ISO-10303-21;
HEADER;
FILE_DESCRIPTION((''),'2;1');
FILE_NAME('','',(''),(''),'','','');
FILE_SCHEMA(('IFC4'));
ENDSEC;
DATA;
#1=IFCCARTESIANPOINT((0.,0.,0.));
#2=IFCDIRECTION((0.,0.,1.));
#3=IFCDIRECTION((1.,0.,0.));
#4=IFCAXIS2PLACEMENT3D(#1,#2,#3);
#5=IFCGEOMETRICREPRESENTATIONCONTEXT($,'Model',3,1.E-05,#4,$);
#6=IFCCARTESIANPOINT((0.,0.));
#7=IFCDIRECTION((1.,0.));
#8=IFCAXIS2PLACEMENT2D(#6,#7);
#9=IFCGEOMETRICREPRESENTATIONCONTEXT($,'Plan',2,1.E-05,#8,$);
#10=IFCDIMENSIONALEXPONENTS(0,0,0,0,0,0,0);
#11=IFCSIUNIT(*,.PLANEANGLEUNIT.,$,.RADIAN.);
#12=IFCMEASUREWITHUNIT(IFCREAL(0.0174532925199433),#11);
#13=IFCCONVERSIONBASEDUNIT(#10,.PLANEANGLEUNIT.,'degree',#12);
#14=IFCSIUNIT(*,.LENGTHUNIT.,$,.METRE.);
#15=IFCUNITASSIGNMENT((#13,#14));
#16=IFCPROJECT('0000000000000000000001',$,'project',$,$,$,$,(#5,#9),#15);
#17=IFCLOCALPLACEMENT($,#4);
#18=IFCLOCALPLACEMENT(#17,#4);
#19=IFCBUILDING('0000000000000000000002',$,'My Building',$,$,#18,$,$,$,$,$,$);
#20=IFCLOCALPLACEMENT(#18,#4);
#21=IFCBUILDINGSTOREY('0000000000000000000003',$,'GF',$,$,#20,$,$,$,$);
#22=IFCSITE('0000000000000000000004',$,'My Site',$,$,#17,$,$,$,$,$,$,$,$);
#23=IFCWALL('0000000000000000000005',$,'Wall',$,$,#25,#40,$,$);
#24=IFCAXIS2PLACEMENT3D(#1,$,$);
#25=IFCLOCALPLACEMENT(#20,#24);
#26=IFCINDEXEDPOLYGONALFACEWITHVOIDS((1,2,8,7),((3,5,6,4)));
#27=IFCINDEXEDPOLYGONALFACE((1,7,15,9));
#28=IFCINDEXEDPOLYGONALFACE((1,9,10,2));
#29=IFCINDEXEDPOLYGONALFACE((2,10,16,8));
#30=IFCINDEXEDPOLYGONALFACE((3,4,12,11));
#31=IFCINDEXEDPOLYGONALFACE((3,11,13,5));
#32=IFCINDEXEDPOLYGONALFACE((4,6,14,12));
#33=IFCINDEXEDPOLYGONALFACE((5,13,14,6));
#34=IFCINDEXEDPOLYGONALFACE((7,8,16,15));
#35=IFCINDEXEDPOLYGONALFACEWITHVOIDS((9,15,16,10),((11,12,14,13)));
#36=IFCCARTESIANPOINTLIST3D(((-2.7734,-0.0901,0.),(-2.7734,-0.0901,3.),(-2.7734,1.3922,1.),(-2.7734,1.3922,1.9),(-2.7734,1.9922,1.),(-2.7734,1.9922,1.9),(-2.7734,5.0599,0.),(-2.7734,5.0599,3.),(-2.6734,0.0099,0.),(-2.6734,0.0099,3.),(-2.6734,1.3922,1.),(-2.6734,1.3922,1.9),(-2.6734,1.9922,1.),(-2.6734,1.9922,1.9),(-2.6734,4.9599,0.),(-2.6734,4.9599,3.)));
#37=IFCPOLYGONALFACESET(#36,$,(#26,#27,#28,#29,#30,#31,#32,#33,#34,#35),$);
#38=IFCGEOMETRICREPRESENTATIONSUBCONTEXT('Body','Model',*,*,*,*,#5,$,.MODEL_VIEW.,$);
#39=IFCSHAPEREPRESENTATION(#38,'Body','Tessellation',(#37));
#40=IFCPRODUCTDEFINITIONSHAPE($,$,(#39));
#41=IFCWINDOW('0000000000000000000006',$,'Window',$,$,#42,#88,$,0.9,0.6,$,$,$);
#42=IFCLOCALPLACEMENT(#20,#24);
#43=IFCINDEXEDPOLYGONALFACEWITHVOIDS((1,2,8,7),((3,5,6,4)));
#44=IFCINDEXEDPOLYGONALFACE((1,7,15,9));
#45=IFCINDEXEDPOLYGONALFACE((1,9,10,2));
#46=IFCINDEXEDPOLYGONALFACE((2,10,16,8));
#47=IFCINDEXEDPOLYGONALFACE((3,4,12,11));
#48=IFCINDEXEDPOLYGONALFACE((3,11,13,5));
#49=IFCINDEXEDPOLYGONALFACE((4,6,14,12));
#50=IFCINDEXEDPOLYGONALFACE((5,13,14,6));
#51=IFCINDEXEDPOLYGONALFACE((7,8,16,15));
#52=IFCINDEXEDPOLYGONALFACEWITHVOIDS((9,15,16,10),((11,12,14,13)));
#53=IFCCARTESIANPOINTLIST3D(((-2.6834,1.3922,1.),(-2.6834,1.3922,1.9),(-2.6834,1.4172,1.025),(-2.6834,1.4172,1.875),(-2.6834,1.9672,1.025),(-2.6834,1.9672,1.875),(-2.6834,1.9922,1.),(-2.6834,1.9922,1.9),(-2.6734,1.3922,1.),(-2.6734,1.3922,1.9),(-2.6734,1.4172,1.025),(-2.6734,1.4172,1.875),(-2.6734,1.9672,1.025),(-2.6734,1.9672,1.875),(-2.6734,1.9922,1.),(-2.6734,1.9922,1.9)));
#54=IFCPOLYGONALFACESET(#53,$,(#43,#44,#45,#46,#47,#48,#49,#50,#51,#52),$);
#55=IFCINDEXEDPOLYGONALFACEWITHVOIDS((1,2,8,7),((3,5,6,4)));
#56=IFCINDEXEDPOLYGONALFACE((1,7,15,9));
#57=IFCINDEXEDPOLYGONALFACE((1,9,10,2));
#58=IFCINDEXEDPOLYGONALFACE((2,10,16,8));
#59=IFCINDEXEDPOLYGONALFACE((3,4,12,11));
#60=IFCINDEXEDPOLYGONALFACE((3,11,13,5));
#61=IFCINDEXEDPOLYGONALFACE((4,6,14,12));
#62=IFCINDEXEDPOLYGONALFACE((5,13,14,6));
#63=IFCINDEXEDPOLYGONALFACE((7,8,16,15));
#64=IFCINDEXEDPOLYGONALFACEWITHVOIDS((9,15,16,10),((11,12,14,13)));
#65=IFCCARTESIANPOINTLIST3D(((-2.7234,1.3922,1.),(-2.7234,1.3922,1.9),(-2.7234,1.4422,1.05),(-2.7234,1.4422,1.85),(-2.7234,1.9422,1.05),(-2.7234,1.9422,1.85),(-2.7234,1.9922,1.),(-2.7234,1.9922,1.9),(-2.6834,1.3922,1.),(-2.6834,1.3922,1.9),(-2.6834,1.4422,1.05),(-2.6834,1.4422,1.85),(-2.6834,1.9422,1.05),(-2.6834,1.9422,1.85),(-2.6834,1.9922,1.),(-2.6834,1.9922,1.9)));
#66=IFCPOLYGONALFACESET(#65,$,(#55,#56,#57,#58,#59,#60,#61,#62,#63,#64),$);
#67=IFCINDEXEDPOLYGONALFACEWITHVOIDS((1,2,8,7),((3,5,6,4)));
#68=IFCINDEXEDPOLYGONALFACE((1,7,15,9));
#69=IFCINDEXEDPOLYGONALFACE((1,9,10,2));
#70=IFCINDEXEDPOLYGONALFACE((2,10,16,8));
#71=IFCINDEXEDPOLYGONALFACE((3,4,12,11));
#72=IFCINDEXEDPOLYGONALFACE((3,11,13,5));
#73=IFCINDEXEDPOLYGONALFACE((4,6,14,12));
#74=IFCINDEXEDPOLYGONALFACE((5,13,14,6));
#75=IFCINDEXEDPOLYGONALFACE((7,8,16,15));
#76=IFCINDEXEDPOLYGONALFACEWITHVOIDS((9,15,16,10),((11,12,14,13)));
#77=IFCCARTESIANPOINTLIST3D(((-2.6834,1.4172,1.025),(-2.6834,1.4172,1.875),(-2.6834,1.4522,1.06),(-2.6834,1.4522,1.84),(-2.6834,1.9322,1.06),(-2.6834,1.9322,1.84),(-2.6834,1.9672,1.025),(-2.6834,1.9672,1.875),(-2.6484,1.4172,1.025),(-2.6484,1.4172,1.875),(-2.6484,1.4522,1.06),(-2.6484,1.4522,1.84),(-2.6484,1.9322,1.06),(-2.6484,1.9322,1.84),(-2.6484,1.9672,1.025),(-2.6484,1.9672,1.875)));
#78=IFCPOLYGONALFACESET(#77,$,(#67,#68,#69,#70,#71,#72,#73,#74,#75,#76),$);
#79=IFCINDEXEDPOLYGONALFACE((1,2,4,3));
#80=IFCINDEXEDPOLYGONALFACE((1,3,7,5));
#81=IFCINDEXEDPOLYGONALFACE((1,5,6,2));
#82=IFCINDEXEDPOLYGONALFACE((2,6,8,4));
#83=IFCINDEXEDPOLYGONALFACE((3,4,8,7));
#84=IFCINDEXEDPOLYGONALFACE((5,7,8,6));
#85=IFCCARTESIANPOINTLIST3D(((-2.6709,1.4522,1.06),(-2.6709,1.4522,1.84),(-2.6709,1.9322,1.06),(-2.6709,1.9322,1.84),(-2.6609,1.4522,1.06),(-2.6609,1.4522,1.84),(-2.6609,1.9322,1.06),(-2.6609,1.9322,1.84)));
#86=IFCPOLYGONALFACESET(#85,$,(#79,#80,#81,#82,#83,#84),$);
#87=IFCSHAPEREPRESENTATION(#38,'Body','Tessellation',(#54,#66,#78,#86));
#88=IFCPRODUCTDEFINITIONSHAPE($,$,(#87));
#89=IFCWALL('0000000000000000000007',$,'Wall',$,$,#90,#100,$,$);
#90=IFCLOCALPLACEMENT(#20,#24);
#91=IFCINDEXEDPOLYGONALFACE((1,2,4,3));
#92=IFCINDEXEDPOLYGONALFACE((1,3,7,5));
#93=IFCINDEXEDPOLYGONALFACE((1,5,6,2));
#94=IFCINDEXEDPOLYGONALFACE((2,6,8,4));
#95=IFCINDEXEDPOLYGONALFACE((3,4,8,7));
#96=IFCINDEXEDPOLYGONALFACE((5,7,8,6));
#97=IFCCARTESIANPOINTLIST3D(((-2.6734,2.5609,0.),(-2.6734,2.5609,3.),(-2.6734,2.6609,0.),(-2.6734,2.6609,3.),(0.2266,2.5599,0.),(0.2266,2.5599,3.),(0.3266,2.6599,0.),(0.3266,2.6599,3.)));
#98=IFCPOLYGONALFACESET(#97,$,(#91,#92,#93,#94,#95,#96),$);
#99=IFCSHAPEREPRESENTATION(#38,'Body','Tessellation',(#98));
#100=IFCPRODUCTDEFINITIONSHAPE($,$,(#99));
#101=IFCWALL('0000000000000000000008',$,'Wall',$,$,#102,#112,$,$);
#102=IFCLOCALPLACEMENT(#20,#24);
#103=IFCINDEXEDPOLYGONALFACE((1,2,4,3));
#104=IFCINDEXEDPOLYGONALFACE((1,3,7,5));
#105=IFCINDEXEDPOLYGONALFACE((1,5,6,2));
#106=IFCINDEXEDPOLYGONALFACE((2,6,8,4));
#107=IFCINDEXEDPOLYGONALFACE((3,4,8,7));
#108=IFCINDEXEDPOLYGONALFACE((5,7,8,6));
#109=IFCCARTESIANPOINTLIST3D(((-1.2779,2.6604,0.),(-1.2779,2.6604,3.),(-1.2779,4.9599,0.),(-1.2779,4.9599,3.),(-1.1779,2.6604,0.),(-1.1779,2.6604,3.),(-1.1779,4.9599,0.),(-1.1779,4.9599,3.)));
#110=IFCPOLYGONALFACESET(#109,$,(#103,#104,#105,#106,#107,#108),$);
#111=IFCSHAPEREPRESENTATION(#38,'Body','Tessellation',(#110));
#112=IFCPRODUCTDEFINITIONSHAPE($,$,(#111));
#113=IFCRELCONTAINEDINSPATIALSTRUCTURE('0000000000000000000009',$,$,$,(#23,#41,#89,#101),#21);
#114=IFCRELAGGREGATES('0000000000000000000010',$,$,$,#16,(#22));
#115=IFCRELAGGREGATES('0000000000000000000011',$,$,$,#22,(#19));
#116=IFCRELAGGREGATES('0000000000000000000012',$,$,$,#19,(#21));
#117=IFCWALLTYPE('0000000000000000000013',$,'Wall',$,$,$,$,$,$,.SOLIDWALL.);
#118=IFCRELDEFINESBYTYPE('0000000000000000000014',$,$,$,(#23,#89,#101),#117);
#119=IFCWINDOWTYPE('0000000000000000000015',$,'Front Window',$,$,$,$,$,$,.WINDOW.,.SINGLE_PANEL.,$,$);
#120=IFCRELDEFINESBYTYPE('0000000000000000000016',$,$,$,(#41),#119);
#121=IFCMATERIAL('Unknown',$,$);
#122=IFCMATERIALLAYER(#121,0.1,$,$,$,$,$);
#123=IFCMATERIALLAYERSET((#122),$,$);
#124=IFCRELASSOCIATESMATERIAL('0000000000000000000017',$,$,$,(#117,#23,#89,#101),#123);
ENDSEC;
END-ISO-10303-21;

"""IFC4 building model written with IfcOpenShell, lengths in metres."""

from ifc_helpers import new_model, entity, si_unit, converted_unit, frame, origin_with_axes, origin_2d_with_axis, place, context, subcontext, project, spatial, line, indexed_curve, outline, extrude, shape, source, transform, mapped, material, layer, layer_set, layer_usage, type_object, type_shapes, element, fill, save


model = new_model("IFC4")

# Units and contexts
model_context = context("Model", 3, precision=1e-05, world=origin_with_axes())
plan_context = context("Plan", 2, precision=1e-05, world=origin_2d_with_axis())
body_context_1 = subcontext(model_context, "Body", "Model", "MODEL_VIEW")
body_context_2 = subcontext(plan_context, "Body", "Plan", "PLAN_VIEW")
ifc_project = project(units=[converted_unit("PLANEANGLEUNIT", "degree", entity("IfcReal", 0.0174532925199433), si_unit("PLANEANGLEUNIT", "RADIAN"), dimensions=[0, 0, 0, 0, 0, 0, 0]), si_unit("LENGTHUNIT", "METRE")], contexts=[model_context, plan_context])

# Site, building, storey
site_placement = place(None, origin_with_axes())
site = spatial("IfcSite", under=ifc_project, at=site_placement, Name="My Site")
building_placement = place(site_placement, origin_with_axes())
building = spatial("IfcBuilding", under=site, at=building_placement, Name="My Building")
storey_placement = place(building_placement, origin_with_axes())
storey = spatial("IfcBuildingStorey", under=building, at=storey_placement, Name="GF")

# Shared definitions
ifc_material = material(Name="Unknown")

# Shared definitions
ifc_layer = layer(ifc_material, 0.1)
ifc_layer_set = layer_set([ifc_layer])
wall_type = type_object("IfcWallType", Name="Wall", PredefinedType="SOLIDWALL", material=ifc_layer_set)

# Wall, opening, window
ifc_layer_usage_1 = layer_usage(ifc_layer_set, "AXIS2", "POSITIVE", 0.0)
wall_1_placement = place(storey_placement, frame((-2.7734, 5.0599, 0.0), z_axis=(0.0, 0.0, 1.0), x_axis=(0.0, -1.0, 0.0)))
wall_1 = element("IfcWall", 1, at=wall_1_placement, inside=storey, type_object=wall_type, material=ifc_layer_usage_1, Name="Wall", context=body_context_1, shape_type="SweptSolid", body=[
    extrude(outline(indexed_curve([(0.0, 0.0), (0.1, 0.1), (5.05, 0.1), (5.15, 0.0)], segments=[line(1, 2, 3, 4, 1)])), origin_with_axes(), (0.0, 0.0, 1.0), 3.0),
])
shared_shape_1 = source(origin_with_axes(), body_context_1, "Body", "SweptSolid", [
    extrude(outline(indexed_curve([(0.0, 0.0), (0.6, 0.0), (0.6, 0.9), (0.0, 0.9)], segments=[line(1, 2, 3, 4, 1)])), frame((0.0, -0.6, 0.0), z_axis=(0.0, -1.0, 0.0), x_axis=(1.0, 0.0, 0.0)), (0.0, 0.0, -1.0), 1.2),
])
opening_1_placement = place(wall_1_placement, frame((3.0677, 0.0, 1.0), z_axis=(0.0, 0.0, 1.0), x_axis=(1.0, 0.0, 0.0)))
opening_1 = element("IfcOpeningElement", 2, at=opening_1_placement, cuts=wall_1, PredefinedType="OPENING", context=body_context_1, shape_type="MappedRepresentation", body=[
    mapped(shared_shape_1, transform((0.0, 0.0, 0.0), x_axis=(1.0, 0.0, 0.0), y_axis=(0.0, 1.0, 0.0), z_axis=(0.0, 0.0, 1.0), scale=1.0)),
])
window_type_1 = type_object("IfcWindowType", Name="Front Window", PartitioningType="SINGLE_PANEL", PredefinedType="WINDOW")
shared_shape_2 = source(origin_with_axes(), body_context_1, "Body", "SweptSolid", [
    extrude(outline(indexed_curve([(0.0, 0.0), (0.6, 0.0), (0.6, 0.9), (0.0, 0.9)], segments=[line(1, 2, 3, 4, 1)]), holes=[indexed_curve([(0.025, 0.025), (0.575, 0.025), (0.575, 0.875), (0.025, 0.875)], segments=[line(1, 2, 3, 4, 1)])]), frame((0.0, 0.09, 0.0), z_axis=(0.0, -1.0, 0.0), x_axis=(1.0, 0.0, 0.0)), (0.0, 0.0, -1.0), 0.01),
    extrude(outline(indexed_curve([(0.0, 0.0), (0.6, 0.0), (0.6, 0.9), (0.0, 0.9)], segments=[line(1, 2, 3, 4, 1)]), holes=[indexed_curve([(0.05, 0.05), (0.55, 0.05), (0.55, 0.85), (0.05, 0.85)], segments=[line(1, 2, 3, 4, 1)])]), frame((0.0, 0.05, 0.0), z_axis=(0.0, -1.0, 0.0), x_axis=(1.0, 0.0, 0.0)), (0.0, 0.0, -1.0), 0.04),
    extrude(outline(indexed_curve([(0.0, 0.0), (0.55, 0.0), (0.55, 0.85), (0.0, 0.85)], segments=[line(1, 2, 3, 4, 1)]), holes=[indexed_curve([(0.035, 0.035), (0.515, 0.035), (0.515, 0.815), (0.035, 0.815)], segments=[line(1, 2, 3, 4, 1)])]), frame((0.025, 0.09, 0.025), z_axis=(0.0, -1.0, 0.0), x_axis=(1.0, 0.0, 0.0)), (0.0, 0.0, -1.0), 0.035),
    extrude(outline(indexed_curve([(0.035, 0.035), (0.515, 0.035), (0.515, 0.815), (0.035, 0.815)], segments=[line(1, 2, 3, 4, 1)])), frame((0.025, 0.1025, 0.025), z_axis=(0.0, -1.0, 0.0), x_axis=(1.0, 0.0, 0.0)), (0.0, 0.0, -1.0), 0.01),
])
shared_shape_3 = source(origin_with_axes(), body_context_2, "Body", "Curve2D", [
    entity("IfcIndexedPolyCurve", entity("IfcCartesianPointList2D", [[0.05, 0.05], [0.55, 0.05]])),
    entity("IfcIndexedPolyCurve", entity("IfcCartesianPointList2D", [[0.0, 0.1], [0.025, 0.1], [0.025, 0.09], [0.05, 0.09], [0.05, 0.05], [0.0, 0.05]]), [entity("IfcLineIndex", [1, 2, 3, 4, 5, 6, 1])]),
    entity("IfcIndexedPolyCurve", entity("IfcCartesianPointList2D", [[0.6, 0.1], [0.575, 0.1], [0.575, 0.09], [0.55, 0.09], [0.55, 0.05], [0.6, 0.05]]), [entity("IfcLineIndex", [1, 2, 3, 4, 5, 6, 1])]),
    entity("IfcIndexedPolyCurve", entity("IfcCartesianPointList2D", [[0.025, 0.09], [0.06, 0.09], [0.06, 0.125], [0.025, 0.125]]), [entity("IfcLineIndex", [1, 2, 3, 4, 1])]),
    entity("IfcIndexedPolyCurve", entity("IfcCartesianPointList2D", [[0.575, 0.09], [0.54, 0.09], [0.54, 0.125], [0.575, 0.125]]), [entity("IfcLineIndex", [1, 2, 3, 4, 1])]),
    entity("IfcIndexedPolyCurve", entity("IfcCartesianPointList2D", [[0.06, 0.09], [0.54, 0.09]])),
    entity("IfcIndexedPolyCurve", entity("IfcCartesianPointList2D", [[0.06, 0.125], [0.54, 0.125]])),
    entity("IfcIndexedPolyCurve", entity("IfcCartesianPointList2D", [[0.06, 0.1075], [0.54, 0.1075]])),
])
type_shapes(window_type_1, [shared_shape_2, shared_shape_3])
window_1_placement = place(opening_1_placement, frame((0.0, 0.0, 0.0), z_axis=(0.0, 0.0, 1.0), x_axis=(1.0, 0.0, 0.0)))
window_1 = element("IfcWindow", 3, at=window_1_placement, inside=storey, type_object=window_type_1, Name="Window", OverallHeight=0.9, OverallWidth=0.6, shapes=[
    shape(body_context_1, "Body", "MappedRepresentation", [mapped(shared_shape_2, transform((0.0, 0.0, 0.0), x_axis=(1.0, 0.0, 0.0), y_axis=(0.0, 1.0, 0.0), z_axis=(0.0, 0.0, 1.0), scale=1.0))]),
    shape(body_context_2, "Body", "MappedRepresentation", [mapped(shared_shape_3, transform((0.0, 0.0, 0.0), x_axis=(1.0, 0.0, 0.0), y_axis=(0.0, 1.0, 0.0), z_axis=(0.0, 0.0, 1.0), scale=1.0))]),
])
fill(opening_1, window_1)

# Walls
ifc_layer_usage_2 = layer_usage(ifc_layer_set, "AXIS2", "POSITIVE", 0.0)
wall_2_placement = place(storey_placement, frame((0.3266, 2.6599, 0.0), z_axis=(0.0, 0.0, 1.0), x_axis=(-1.0, 0.00034, 0.0)))
element("IfcWall", 4, at=wall_2_placement, inside=storey, type_object=wall_type, material=ifc_layer_usage_2, Name="Wall", context=body_context_1, shape_type="SweptSolid", body=[
    extrude(outline(indexed_curve([(0.0, 0.0), (0.1, 0.1), (3.0, 0.1), (3.0, 0.0)], segments=[line(1, 2, 3, 4, 1)])), origin_with_axes(), (0.0, 0.0, 1.0), 3.0),
])
ifc_layer_usage_3 = layer_usage(ifc_layer_set, "AXIS2", "POSITIVE", 0.0)
wall_3_placement = place(storey_placement, frame((-1.2779, 4.9599, 0.0), z_axis=(0.0, 0.0, 1.0), x_axis=(0.0, -1.0, 0.0)))
element("IfcWall", 5, at=wall_3_placement, inside=storey, type_object=wall_type, material=ifc_layer_usage_3, Name="Wall", context=body_context_1, shape_type="SweptSolid", body=[
    extrude(outline(indexed_curve([(0.0, 0.0), (0.0, 0.1), (2.2995, 0.1), (2.2995, 0.0)], segments=[line(1, 2, 3, 4, 1)])), origin_with_axes(), (0.0, 0.0, 1.0), 3.0),
])

save(model, "model.ifc")
